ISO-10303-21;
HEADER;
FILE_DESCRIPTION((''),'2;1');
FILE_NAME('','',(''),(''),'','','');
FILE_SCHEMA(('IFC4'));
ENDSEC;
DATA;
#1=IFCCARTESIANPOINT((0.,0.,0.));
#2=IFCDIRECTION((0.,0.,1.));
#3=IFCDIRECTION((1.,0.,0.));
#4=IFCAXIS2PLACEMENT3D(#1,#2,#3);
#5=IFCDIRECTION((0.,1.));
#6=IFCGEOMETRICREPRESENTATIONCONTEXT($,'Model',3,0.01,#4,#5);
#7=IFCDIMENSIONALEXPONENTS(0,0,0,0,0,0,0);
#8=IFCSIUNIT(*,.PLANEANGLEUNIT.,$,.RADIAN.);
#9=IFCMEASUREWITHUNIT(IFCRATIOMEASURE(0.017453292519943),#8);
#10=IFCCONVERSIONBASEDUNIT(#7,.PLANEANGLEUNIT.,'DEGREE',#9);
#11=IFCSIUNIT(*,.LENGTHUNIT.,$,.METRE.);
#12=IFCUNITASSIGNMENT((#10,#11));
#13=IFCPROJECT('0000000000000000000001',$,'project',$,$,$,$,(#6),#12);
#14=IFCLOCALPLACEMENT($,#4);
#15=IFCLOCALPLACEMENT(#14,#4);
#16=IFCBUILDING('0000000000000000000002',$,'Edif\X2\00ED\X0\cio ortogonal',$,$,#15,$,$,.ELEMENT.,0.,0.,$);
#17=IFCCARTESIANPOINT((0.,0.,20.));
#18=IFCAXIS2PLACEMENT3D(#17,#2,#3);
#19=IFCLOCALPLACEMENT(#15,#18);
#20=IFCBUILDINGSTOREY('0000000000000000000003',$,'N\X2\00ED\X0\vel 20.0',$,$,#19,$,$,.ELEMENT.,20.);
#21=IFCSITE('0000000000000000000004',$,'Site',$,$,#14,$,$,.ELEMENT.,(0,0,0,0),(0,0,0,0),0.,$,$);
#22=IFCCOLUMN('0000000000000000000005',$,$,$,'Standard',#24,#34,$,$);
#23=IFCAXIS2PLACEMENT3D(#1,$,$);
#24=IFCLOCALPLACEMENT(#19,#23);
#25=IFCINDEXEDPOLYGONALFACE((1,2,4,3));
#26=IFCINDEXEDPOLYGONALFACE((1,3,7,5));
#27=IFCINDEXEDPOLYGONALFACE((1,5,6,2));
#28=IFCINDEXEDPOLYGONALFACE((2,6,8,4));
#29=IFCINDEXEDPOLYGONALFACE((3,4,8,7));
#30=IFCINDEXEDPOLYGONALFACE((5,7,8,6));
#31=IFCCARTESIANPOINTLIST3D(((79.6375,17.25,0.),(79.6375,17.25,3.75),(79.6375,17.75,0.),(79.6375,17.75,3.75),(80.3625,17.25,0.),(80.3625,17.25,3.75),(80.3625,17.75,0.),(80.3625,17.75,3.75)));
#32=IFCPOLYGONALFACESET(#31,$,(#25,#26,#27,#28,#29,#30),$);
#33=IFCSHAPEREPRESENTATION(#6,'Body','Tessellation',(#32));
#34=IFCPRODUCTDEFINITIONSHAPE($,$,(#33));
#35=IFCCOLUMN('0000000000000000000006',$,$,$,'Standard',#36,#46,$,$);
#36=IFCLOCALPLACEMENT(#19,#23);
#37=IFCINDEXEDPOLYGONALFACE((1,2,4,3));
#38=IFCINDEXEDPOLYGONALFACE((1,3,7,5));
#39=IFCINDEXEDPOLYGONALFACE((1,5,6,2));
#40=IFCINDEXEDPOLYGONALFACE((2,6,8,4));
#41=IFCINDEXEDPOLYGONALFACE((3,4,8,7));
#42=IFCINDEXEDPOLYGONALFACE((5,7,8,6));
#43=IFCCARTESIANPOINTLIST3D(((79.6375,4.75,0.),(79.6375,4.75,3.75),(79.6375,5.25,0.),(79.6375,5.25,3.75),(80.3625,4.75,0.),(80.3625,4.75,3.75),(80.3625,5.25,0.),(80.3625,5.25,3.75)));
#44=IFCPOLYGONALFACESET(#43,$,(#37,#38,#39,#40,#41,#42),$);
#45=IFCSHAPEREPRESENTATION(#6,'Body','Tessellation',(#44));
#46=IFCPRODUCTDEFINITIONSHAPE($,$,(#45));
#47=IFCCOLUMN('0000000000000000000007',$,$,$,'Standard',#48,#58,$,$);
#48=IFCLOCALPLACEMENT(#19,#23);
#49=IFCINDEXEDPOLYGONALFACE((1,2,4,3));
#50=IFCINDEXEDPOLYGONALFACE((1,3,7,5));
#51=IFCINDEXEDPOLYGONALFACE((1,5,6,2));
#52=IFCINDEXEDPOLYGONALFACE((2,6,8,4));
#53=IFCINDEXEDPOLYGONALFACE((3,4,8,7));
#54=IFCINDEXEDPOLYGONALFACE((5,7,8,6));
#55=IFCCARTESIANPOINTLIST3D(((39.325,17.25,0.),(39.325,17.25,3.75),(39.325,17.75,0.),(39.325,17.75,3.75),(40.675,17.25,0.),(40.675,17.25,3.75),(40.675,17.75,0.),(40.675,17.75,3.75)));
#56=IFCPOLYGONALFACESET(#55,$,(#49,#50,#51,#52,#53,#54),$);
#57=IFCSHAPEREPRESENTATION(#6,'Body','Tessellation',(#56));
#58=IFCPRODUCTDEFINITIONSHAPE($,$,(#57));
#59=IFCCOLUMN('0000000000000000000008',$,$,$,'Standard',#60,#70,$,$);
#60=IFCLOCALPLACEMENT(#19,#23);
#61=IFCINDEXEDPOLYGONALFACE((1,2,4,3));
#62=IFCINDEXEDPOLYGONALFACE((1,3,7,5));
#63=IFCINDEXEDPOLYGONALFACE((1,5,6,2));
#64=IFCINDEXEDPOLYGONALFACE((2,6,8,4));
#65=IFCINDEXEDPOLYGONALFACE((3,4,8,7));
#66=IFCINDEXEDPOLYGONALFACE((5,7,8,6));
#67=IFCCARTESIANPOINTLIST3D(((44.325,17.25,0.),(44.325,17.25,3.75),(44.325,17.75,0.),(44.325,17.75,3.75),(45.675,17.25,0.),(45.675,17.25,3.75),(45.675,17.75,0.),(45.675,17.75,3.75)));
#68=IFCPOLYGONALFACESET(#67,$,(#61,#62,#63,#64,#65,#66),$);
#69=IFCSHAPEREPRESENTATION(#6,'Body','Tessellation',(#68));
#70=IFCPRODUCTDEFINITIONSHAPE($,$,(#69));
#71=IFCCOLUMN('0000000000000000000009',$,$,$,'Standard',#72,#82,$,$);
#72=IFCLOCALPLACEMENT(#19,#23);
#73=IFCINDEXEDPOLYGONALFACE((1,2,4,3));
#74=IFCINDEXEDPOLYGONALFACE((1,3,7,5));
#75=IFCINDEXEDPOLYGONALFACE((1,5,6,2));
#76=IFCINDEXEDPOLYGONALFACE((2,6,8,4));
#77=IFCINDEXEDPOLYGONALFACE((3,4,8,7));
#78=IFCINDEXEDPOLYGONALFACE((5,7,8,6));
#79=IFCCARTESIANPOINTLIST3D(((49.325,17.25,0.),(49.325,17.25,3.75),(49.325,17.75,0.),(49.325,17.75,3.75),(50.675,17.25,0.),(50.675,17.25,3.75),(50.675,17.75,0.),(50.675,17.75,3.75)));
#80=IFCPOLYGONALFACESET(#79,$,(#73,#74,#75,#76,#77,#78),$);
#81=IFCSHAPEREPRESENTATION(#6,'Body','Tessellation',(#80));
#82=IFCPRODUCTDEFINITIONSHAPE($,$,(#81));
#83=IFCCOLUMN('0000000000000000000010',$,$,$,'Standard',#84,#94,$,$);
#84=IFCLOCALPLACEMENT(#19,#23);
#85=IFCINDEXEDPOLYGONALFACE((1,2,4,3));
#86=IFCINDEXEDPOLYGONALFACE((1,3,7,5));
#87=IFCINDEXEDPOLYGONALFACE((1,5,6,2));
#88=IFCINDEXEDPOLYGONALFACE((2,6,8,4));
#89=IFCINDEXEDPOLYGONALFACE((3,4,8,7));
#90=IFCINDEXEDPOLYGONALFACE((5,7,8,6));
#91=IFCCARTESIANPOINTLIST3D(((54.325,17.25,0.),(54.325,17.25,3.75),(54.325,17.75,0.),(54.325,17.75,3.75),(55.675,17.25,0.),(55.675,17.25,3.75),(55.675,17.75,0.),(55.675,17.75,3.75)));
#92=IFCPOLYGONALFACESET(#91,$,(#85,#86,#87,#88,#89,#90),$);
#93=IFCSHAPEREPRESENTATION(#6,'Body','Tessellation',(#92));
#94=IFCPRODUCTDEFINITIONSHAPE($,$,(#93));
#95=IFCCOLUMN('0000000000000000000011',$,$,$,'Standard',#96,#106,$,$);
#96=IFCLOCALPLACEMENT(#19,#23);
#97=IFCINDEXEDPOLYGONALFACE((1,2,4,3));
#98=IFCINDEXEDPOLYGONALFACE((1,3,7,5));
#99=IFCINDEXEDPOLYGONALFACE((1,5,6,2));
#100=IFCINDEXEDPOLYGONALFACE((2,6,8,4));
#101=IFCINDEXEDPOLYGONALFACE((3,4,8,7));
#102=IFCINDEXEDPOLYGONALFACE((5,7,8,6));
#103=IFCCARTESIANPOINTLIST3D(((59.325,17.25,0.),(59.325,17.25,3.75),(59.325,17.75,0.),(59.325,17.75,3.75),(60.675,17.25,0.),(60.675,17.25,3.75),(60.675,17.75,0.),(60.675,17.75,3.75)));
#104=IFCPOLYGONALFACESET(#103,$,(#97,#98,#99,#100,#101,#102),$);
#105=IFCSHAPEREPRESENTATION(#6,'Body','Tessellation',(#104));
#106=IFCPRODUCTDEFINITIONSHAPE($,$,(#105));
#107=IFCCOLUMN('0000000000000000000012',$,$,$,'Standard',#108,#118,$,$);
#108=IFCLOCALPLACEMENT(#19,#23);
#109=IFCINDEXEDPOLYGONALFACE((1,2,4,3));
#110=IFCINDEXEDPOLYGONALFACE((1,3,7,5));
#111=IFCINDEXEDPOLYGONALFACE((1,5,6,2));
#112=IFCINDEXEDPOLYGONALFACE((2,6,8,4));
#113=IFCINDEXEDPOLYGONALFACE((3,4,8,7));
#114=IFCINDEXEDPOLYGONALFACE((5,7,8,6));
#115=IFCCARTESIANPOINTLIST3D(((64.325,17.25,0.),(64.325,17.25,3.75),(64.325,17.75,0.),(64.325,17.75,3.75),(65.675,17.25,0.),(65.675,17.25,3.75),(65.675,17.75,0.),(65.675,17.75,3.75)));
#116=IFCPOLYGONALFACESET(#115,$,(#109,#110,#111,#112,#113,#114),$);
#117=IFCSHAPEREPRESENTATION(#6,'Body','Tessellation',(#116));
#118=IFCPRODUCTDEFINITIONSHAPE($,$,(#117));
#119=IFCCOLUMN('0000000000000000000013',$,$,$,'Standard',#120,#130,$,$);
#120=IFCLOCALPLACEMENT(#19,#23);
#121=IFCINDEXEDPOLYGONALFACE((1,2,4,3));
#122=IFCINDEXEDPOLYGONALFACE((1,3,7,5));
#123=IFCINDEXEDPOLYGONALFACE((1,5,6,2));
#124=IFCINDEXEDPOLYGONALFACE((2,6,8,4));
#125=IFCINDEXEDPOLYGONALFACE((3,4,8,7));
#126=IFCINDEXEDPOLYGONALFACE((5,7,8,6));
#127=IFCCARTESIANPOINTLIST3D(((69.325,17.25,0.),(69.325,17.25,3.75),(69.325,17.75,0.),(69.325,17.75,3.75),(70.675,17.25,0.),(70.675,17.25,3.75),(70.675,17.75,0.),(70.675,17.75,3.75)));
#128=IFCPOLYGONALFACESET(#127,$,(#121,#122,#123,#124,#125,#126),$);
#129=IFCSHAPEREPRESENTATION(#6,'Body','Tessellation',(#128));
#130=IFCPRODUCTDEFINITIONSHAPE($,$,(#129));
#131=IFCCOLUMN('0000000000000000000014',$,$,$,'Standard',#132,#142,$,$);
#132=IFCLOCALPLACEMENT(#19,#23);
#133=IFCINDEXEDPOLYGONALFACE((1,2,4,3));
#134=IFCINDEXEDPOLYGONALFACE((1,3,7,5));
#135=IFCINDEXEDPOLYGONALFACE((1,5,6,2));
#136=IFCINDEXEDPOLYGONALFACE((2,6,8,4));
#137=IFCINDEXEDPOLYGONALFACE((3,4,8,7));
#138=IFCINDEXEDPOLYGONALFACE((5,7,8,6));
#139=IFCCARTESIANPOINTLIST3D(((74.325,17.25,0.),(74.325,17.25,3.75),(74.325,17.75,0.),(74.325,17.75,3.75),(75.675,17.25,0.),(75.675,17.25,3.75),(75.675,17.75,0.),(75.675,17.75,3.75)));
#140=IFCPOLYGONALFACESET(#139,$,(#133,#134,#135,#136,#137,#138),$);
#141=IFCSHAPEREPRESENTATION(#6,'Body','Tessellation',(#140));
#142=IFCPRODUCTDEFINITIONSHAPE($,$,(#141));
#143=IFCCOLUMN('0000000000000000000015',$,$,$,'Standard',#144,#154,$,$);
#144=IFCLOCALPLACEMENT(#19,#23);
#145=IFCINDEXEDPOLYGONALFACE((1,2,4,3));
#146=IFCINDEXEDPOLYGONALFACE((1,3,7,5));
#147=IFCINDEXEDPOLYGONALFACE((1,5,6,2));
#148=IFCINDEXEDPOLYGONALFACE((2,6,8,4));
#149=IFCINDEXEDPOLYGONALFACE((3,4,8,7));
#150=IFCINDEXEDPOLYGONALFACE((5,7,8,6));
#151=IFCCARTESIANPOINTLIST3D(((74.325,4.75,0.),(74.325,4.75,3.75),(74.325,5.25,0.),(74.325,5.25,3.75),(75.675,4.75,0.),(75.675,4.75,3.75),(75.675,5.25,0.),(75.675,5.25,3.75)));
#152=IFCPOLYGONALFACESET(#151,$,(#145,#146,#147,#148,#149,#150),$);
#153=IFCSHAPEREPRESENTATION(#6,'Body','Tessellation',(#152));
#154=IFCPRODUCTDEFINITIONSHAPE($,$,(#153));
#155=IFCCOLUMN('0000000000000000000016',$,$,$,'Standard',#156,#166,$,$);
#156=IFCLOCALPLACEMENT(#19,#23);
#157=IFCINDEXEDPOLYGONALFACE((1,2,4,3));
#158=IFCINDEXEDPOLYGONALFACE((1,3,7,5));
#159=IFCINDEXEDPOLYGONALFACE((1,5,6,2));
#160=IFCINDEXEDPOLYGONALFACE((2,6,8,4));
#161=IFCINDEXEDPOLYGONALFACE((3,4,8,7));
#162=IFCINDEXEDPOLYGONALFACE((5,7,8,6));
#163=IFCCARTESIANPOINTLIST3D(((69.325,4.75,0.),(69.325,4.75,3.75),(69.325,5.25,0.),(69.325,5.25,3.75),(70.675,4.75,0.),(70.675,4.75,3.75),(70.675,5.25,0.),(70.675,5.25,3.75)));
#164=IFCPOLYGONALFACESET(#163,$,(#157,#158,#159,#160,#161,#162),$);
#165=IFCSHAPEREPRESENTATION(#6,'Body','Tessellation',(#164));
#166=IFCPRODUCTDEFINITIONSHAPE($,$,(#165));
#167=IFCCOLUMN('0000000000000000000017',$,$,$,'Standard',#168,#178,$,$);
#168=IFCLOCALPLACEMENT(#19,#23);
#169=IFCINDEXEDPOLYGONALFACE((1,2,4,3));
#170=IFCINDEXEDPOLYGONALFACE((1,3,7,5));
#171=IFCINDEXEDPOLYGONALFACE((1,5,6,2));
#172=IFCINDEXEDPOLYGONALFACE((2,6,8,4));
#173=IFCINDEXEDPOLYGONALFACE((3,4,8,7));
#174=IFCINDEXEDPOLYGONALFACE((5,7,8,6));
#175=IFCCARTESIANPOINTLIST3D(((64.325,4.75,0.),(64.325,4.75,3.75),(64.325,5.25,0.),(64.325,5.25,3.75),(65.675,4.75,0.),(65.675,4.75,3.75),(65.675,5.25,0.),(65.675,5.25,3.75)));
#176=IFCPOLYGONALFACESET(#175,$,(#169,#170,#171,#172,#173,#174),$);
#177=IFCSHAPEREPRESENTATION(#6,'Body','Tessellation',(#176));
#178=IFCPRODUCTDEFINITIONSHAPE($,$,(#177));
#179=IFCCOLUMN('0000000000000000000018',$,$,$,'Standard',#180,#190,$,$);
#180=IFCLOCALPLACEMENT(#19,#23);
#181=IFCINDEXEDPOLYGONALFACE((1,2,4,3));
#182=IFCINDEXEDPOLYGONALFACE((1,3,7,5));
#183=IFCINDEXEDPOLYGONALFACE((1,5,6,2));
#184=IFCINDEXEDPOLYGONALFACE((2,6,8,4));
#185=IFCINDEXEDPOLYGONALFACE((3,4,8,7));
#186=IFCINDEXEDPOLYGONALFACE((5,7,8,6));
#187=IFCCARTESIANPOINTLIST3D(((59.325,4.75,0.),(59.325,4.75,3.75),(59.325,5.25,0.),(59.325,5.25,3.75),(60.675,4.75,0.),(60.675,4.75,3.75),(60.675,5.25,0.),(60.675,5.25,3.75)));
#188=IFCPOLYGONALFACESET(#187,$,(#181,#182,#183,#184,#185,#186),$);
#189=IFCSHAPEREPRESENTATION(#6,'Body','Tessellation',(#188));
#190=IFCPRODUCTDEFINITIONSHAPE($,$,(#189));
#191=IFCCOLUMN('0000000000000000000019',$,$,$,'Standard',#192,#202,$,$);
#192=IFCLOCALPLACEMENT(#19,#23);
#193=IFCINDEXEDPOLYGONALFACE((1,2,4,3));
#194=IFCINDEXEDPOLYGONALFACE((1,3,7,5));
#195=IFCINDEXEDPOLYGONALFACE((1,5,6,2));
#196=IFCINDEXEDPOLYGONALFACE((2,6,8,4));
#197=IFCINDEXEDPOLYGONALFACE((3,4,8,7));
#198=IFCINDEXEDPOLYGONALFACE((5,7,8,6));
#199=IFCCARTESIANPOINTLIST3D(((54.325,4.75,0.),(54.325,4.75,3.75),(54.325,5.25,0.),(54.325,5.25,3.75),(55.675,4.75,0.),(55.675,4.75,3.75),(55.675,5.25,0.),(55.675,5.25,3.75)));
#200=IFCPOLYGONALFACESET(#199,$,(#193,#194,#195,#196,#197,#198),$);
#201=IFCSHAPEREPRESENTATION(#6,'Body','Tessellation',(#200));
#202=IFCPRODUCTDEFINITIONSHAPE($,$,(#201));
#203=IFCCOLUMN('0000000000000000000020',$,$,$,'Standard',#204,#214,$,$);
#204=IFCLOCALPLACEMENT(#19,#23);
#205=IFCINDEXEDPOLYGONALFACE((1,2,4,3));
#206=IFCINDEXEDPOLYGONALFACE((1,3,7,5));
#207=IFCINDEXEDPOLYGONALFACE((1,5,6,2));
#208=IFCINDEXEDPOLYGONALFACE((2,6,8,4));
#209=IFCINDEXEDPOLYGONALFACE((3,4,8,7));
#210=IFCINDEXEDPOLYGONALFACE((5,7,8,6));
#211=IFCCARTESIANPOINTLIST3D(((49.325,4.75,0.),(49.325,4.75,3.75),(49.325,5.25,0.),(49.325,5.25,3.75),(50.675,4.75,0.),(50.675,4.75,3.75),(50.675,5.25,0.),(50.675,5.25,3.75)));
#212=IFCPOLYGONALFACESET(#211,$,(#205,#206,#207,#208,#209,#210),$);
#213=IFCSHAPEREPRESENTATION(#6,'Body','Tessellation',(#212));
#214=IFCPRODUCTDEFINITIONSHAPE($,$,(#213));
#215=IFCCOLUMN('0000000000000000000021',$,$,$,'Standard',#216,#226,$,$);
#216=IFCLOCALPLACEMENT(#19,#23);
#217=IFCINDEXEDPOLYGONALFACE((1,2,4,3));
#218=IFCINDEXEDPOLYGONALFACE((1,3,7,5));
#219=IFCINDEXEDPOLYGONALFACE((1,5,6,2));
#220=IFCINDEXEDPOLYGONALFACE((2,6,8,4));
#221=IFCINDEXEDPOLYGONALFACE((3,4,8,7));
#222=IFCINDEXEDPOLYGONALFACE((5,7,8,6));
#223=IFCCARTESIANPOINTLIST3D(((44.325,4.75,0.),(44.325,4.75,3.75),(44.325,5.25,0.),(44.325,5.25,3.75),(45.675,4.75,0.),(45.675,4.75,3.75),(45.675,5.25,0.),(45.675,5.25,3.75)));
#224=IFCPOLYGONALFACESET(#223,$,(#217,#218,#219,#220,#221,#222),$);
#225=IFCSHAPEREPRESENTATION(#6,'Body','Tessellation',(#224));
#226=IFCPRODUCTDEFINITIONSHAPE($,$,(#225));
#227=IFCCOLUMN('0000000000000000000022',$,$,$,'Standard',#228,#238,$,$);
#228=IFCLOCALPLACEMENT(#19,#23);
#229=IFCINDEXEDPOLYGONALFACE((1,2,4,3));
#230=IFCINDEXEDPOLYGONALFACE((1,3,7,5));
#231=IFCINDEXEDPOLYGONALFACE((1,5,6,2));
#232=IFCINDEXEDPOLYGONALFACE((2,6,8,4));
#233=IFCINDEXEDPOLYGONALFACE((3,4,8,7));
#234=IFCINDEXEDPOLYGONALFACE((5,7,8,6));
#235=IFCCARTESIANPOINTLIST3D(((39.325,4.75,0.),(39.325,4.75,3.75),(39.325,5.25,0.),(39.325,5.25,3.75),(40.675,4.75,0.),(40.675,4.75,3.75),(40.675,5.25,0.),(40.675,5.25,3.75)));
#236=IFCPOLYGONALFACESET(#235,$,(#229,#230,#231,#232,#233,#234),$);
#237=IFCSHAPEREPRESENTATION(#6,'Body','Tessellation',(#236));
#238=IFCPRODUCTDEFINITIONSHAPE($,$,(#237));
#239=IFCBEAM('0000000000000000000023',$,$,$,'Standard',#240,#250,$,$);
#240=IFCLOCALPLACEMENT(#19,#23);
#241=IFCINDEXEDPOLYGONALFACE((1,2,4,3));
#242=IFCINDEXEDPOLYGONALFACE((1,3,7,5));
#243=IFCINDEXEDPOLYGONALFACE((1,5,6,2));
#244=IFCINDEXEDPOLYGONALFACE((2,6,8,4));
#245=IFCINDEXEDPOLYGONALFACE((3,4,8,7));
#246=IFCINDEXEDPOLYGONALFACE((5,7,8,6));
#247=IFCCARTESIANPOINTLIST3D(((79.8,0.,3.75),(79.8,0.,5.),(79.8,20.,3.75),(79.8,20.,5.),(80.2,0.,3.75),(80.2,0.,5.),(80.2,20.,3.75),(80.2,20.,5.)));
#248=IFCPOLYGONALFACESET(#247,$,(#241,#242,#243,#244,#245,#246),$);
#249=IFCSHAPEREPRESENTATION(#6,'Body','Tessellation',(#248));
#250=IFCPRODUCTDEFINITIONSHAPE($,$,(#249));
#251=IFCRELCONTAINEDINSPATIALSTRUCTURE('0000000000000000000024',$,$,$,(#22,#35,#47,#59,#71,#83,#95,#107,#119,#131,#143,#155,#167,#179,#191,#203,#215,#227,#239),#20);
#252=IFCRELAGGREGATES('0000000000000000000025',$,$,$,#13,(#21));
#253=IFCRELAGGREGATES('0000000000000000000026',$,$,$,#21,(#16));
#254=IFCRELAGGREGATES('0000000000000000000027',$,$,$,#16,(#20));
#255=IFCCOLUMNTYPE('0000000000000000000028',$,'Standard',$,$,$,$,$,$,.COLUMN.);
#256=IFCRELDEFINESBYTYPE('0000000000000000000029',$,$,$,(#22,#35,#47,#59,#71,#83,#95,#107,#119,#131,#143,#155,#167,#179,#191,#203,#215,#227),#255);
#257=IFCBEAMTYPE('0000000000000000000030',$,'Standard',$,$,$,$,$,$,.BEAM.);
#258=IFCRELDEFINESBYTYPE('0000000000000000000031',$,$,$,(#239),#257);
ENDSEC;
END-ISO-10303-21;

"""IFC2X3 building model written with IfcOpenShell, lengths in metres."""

from ifc_helpers import new_model, entity, si_unit, converted_unit, direction, frame, origin_with_axes, origin_2d, place, context, project, spatial, polyline, rectangle, outline, extrude, type_object, element, save


model = new_model("IFC2X3")

# Units and contexts
model_context = context("Model", 3, precision=0.01, world=origin_with_axes(), true_north=direction((0.0, 1.0)))
ifc_project = project(units=[converted_unit("PLANEANGLEUNIT", "DEGREE", entity("IfcRatioMeasure", 0.017453292519943), si_unit("PLANEANGLEUNIT", "RADIAN"), dimensions=[0, 0, 0, 0, 0, 0, 0]), si_unit("LENGTHUNIT", "METRE")], contexts=[model_context])

# Site, building, storey
site_placement = place(None, origin_with_axes())
site = spatial("IfcSite", under=ifc_project, at=site_placement, Name="Site", CompositionType="ELEMENT", RefLatitude=(0, 0, 0, 0), RefLongitude=(0, 0, 0, 0), RefElevation=0.0)
building_placement = place(site_placement, origin_with_axes())
building = spatial("IfcBuilding", under=site, at=building_placement, Name="Edifício ortogonal", CompositionType="ELEMENT", ElevationOfRefHeight=0.0, ElevationOfTerrain=0.0)
storey_placement = place(building_placement, frame((0.0, 0.0, 20.0), z_axis=(0.0, 0.0, 1.0), x_axis=(1.0, 0.0, 0.0)))
storey = spatial("IfcBuildingStorey", under=building, at=storey_placement, Name="Nível 20.0", CompositionType="ELEMENT", Elevation=20.0)

# Columns
column_type = type_object("IfcColumnType", Name="Standard", PredefinedType="COLUMN")
for number, where, z_axis, x_axis in (
    (1, (80.0, 17.5, 20.0), (0.0, 0.0, 1.0), (1.0, 0.0, 0.0)),
    (2, (80.0, 5.0, 20.0), (0.0, 0.0, 1.0), (1.0, 0.0, 0.0)),
):
    element("IfcColumn", number, at=place(site_placement, frame(where, z_axis=z_axis, x_axis=x_axis)), inside=storey, type_object=column_type, ObjectType="Standard", context=model_context, shape_type="SweptSolid", body=[
        extrude(outline(polyline([(0.3625, -0.25), (0.3625, 0.25), (-0.3625, 0.25), (-0.3625, -0.25), (0.3625, -0.25)])), origin_with_axes(), (0.0, 0.0, 1.0), 3.75),
    ])
for number, where, z_axis, x_axis in (
    (3, (40.0, 17.5, 20.0), (0.0, 0.0, 1.0), (1.0, 0.0, 0.0)),
    (4, (45.0, 17.5, 20.0), (0.0, 0.0, 1.0), (1.0, 0.0, 0.0)),
    (5, (50.0, 17.5, 20.0), (0.0, 0.0, 1.0), (1.0, 0.0, 0.0)),
    (6, (55.0, 17.5, 20.0), (0.0, 0.0, 1.0), (1.0, 0.0, 0.0)),
    (7, (60.0, 17.5, 20.0), (0.0, 0.0, 1.0), (1.0, 0.0, 0.0)),
    (8, (65.0, 17.5, 20.0), (0.0, 0.0, 1.0), (1.0, 0.0, 0.0)),
    (9, (70.0, 17.5, 20.0), (0.0, 0.0, 1.0), (1.0, 0.0, 0.0)),
    (10, (75.0, 17.5, 20.0), (0.0, 0.0, 1.0), (1.0, 0.0, 0.0)),
    (11, (75.0, 5.0, 20.0), (0.0, 0.0, 1.0), (1.0, 0.0, 0.0)),
    (12, (70.0, 5.0, 20.0), (0.0, 0.0, 1.0), (1.0, 0.0, 0.0)),
    (13, (65.0, 5.0, 20.0), (0.0, 0.0, 1.0), (1.0, 0.0, 0.0)),
    (14, (60.0, 5.0, 20.0), (0.0, 0.0, 1.0), (1.0, 0.0, 0.0)),
    (15, (55.0, 5.0, 20.0), (0.0, 0.0, 1.0), (1.0, 0.0, 0.0)),
    (16, (50.0, 5.0, 20.0), (0.0, 0.0, 1.0), (1.0, 0.0, 0.0)),
    (17, (45.0, 5.0, 20.0), (0.0, 0.0, 1.0), (1.0, 0.0, 0.0)),
    (18, (40.0, 5.0, 20.0), (0.0, 0.0, 1.0), (1.0, 0.0, 0.0)),
):
    element("IfcColumn", number, at=place(site_placement, frame(where, z_axis=z_axis, x_axis=x_axis)), inside=storey, type_object=column_type, ObjectType="Standard", context=model_context, shape_type="SweptSolid", body=[
        extrude(outline(polyline([(0.675, -0.25), (0.675, 0.25), (-0.675, 0.25), (-0.675, -0.25), (0.675, -0.25)])), origin_with_axes(), (0.0, 0.0, 1.0), 3.75),
    ])

# Beam
beam_type = type_object("IfcBeamType", Name="Standard", PredefinedType="BEAM")
for number, where, z_axis, x_axis in (
    (19, (80.0, 20.0, 25.0), (0.0, 0.0, 1.0), (0.0, -1.0, 0.0)),
):
    element("IfcBeam", number, at=place(site_placement, frame(where, z_axis=z_axis, x_axis=x_axis)), inside=storey, type_object=beam_type, ObjectType="Standard", context=model_context, shape_type="SweptSolid", body=[
        extrude(rectangle(XDim=0.4, YDim=1.25, at=origin_2d()), frame((0.0, 0.0, -0.625), z_axis=(1.0, 0.0, 0.0), x_axis=(0.0, 1.0, 0.0)), (0.0, 0.0, 1.0), 20.0),
    ])

save(model, "model.ifc")
